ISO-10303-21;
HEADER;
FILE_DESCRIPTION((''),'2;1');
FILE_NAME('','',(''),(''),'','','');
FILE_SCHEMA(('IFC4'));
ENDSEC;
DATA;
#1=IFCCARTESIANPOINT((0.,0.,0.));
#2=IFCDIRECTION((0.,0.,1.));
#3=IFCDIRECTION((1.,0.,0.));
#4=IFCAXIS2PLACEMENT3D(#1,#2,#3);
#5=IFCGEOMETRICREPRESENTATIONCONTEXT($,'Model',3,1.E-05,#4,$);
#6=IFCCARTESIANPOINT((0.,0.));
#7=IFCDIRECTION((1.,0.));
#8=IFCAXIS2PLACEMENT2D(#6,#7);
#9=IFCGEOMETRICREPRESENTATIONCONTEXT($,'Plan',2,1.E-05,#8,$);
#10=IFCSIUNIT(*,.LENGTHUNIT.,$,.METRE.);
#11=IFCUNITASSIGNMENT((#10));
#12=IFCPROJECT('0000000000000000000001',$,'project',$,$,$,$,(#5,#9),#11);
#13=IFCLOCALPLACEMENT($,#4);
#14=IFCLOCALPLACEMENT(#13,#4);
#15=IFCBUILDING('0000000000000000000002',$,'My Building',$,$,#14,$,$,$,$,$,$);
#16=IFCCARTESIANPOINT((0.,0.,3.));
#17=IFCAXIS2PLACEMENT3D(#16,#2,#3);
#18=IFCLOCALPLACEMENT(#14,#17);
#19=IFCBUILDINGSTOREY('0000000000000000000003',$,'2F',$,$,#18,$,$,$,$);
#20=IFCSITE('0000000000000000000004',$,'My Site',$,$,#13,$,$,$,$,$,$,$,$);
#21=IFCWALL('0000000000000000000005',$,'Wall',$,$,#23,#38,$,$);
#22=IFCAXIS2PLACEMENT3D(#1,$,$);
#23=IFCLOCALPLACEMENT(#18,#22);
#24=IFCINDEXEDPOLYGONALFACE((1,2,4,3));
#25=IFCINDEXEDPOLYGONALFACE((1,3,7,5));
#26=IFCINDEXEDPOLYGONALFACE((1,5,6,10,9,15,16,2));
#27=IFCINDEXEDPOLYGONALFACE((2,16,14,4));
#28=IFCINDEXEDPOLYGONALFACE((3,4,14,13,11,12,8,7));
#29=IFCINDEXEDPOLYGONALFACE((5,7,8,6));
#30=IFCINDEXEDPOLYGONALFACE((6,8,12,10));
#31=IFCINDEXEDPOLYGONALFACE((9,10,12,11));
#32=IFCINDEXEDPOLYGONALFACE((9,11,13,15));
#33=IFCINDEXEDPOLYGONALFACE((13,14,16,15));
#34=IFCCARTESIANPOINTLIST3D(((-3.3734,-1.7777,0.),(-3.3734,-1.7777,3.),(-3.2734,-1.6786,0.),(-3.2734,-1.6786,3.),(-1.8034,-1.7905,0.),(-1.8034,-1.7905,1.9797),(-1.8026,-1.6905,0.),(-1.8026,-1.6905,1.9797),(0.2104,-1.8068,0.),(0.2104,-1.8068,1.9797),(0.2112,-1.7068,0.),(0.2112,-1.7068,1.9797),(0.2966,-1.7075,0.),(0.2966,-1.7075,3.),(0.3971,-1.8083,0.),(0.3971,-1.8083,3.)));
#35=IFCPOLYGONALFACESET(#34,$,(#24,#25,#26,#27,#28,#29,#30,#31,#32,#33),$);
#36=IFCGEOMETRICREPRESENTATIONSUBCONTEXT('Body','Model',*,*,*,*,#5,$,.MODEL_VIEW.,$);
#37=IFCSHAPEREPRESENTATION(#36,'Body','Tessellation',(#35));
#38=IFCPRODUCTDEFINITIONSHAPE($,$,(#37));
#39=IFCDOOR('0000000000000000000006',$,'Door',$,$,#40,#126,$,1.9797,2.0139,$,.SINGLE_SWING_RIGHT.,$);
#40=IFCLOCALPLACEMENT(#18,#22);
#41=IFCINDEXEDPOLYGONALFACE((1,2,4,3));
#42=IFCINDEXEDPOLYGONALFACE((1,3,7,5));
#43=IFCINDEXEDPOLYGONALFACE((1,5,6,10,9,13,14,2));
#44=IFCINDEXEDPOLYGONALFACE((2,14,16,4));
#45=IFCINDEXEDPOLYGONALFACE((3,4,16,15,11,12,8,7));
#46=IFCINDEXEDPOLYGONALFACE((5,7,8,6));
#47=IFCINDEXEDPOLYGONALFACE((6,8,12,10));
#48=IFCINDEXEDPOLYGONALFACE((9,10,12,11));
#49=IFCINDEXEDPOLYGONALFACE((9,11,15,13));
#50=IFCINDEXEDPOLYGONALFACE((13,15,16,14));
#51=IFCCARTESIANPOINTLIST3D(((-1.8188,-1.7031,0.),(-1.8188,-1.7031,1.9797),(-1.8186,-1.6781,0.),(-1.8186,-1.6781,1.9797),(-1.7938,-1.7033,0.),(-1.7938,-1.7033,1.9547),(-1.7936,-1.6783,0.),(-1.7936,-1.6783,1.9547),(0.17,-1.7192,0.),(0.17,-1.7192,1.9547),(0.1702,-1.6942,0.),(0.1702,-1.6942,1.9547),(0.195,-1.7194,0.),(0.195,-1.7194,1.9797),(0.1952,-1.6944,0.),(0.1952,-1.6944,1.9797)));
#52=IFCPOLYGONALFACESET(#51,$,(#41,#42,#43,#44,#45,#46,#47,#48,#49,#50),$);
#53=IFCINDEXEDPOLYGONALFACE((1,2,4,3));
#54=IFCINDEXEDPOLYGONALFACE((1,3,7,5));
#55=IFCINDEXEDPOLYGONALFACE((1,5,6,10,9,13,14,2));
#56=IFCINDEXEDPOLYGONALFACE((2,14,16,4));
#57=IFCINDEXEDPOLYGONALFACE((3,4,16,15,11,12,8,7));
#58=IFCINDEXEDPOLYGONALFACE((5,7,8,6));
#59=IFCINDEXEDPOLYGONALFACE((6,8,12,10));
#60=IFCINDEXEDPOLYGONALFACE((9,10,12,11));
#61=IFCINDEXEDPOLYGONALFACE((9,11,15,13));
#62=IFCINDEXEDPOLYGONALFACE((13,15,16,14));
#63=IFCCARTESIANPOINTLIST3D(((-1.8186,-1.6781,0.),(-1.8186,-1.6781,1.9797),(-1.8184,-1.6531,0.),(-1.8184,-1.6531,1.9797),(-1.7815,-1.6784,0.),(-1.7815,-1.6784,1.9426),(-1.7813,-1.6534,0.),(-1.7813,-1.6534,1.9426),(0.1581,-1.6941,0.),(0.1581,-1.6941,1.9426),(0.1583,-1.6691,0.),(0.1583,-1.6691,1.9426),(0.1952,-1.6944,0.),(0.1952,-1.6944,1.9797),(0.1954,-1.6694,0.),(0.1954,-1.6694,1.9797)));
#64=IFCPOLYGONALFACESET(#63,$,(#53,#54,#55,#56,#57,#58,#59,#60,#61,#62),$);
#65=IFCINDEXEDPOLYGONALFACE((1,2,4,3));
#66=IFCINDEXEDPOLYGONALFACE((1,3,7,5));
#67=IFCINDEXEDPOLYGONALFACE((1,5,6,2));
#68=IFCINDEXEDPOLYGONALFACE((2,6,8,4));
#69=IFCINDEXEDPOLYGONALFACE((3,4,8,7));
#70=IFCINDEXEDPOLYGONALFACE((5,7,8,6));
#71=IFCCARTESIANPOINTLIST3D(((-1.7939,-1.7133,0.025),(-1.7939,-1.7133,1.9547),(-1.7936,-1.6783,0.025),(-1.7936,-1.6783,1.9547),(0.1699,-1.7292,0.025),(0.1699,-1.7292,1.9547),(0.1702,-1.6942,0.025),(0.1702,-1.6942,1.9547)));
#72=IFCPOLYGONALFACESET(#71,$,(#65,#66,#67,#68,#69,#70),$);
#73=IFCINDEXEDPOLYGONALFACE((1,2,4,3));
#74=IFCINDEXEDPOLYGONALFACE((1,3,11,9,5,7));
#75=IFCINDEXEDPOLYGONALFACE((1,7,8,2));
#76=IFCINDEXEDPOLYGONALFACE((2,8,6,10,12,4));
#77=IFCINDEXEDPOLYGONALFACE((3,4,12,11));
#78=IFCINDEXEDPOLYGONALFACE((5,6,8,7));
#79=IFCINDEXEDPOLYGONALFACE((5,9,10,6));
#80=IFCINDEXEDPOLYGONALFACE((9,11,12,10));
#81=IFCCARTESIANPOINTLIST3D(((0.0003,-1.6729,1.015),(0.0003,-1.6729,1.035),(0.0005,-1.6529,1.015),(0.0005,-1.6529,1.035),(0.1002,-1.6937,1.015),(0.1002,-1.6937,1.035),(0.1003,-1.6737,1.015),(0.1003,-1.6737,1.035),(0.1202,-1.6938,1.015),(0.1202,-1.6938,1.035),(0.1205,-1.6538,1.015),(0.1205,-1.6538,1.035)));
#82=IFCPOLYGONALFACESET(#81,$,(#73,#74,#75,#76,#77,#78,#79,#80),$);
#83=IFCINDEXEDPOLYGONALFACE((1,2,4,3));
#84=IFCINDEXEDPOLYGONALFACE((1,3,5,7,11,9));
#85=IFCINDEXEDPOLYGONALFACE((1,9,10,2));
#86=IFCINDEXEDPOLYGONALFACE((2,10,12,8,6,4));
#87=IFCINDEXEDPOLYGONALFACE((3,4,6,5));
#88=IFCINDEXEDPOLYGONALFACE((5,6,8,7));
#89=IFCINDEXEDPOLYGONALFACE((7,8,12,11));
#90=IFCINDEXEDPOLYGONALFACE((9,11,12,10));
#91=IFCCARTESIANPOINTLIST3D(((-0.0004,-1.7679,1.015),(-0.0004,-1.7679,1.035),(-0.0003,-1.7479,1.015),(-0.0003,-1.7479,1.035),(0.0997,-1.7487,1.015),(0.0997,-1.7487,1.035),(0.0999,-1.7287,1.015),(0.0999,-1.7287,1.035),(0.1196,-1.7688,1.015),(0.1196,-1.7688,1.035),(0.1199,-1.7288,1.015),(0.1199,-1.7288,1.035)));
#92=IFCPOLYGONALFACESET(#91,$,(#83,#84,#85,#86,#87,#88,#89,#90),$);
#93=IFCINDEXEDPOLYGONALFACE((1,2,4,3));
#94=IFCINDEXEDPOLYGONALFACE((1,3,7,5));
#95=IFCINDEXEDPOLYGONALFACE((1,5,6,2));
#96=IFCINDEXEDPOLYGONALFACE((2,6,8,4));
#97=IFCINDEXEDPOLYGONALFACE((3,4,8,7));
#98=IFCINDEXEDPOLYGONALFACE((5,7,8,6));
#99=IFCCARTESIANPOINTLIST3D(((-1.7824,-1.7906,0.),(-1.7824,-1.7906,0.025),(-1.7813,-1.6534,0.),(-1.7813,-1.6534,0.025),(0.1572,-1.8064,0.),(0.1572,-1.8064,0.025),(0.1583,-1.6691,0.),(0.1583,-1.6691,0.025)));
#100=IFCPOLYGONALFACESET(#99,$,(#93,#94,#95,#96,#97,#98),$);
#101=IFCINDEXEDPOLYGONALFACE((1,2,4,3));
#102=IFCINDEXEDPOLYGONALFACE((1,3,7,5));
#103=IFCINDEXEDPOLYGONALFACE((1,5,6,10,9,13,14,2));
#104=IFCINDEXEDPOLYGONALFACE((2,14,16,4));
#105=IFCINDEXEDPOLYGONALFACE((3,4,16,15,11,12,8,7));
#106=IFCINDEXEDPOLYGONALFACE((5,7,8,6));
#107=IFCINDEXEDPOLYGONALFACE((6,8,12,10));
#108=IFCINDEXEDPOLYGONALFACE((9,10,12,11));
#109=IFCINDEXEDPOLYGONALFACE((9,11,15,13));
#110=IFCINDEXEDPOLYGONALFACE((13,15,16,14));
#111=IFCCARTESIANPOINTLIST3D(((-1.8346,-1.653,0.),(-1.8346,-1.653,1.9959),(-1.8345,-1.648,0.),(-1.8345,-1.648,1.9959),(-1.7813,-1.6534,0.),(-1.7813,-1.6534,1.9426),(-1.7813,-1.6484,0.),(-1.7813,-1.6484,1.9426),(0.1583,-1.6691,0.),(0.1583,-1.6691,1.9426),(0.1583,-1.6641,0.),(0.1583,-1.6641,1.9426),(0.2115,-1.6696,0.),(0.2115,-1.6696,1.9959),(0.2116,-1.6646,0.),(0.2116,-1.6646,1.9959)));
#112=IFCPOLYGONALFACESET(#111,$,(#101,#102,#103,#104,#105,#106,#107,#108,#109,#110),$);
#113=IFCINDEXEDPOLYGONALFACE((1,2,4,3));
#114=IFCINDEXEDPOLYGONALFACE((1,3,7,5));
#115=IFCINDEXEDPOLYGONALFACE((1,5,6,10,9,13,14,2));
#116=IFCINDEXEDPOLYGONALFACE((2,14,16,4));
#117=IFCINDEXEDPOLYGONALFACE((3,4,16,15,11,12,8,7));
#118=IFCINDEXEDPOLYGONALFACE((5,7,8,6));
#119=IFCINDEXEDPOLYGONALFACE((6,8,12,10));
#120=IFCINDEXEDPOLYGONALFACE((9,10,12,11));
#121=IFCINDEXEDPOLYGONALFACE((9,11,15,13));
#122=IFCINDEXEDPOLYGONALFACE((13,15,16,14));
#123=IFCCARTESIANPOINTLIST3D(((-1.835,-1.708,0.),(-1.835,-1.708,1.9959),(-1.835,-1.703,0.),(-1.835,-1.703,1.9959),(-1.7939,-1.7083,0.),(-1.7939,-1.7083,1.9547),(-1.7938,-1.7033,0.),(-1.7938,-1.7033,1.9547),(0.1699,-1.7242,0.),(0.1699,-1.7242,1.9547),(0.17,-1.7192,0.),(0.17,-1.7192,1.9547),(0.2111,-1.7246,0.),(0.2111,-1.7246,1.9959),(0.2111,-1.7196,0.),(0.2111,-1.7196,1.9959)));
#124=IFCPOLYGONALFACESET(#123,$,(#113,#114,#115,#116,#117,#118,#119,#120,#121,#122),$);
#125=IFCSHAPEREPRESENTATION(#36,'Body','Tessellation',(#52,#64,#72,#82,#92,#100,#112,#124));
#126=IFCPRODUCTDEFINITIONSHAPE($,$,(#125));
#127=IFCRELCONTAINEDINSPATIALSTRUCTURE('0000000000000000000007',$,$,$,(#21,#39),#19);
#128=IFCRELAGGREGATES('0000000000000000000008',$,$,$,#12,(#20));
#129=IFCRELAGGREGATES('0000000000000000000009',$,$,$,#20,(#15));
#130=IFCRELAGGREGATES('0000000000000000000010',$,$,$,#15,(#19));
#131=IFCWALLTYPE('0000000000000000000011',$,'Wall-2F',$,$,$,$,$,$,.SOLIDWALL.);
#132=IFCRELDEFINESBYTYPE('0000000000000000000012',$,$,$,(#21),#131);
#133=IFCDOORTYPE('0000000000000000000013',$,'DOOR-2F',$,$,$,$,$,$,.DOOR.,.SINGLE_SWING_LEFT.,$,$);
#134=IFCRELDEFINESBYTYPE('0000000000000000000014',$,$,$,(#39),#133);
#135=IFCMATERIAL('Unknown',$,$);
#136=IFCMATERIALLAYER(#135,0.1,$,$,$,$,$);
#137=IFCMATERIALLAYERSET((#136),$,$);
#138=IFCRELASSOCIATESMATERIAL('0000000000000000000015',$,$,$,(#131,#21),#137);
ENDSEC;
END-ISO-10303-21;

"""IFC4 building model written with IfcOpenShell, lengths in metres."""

from ifc_helpers import new_model, entity, si_unit, frame, origin_with_axes, origin_2d_with_axis, place, context, subcontext, project, spatial, line, indexed_curve, outline, extrude, shape, source, transform, mapped, material, layer, layer_set, layer_usage, type_object, type_shapes, element, fill, save


model = new_model("IFC4")

# Units and contexts
model_context = context("Model", 3, precision=1e-05, world=origin_with_axes())
plan_context = context("Plan", 2, precision=1e-05, world=origin_2d_with_axis())
body_context_1 = subcontext(model_context, "Body", "Model", "MODEL_VIEW")
body_context_2 = subcontext(plan_context, "Body", "Plan", "PLAN_VIEW")
ifc_project = project(units=[si_unit("LENGTHUNIT", "METRE")], contexts=[model_context, plan_context])

# Site, building, storey
site_placement = place(None, origin_with_axes())
site = spatial("IfcSite", under=ifc_project, at=site_placement, Name="My Site")
building_placement = place(site_placement, origin_with_axes())
building = spatial("IfcBuilding", under=site, at=building_placement, Name="My Building")
storey_placement = place(building_placement, frame((0.0, 0.0, 3.0), z_axis=(0.0, 0.0, 1.0), x_axis=(1.0, 0.0, 0.0)))
storey = spatial("IfcBuildingStorey", under=building, at=storey_placement, Name="2F")

# Shared definitions
ifc_material = material(Name="Unknown")

# Shared definitions
ifc_layer_1 = layer(ifc_material, 0.1)
ifc_layer_set_1 = layer_set([ifc_layer_1])
wall_type = type_object("IfcWallType", Name="Wall-2F", PredefinedType="SOLIDWALL", material=ifc_layer_set_1)

# Wall, opening, door
ifc_layer_usage_1 = layer_usage(ifc_layer_set_1, "AXIS2", "POSITIVE", 0.0)
wall_1_placement = place(storey_placement, frame((0.2966, -1.7075, 0.0), z_axis=(0.0, 0.0, 1.0), x_axis=(-0.999967, 0.008106, 0.0)))
wall_1 = element("IfcWall", 1, at=wall_1_placement, inside=storey, type_object=wall_type, material=ifc_layer_usage_1, Name="Wall", context=body_context_1, shape_type="SweptSolid", body=[
    extrude(outline(indexed_curve([(0.0, 0.0), (-0.1013, 0.1), (3.6693, 0.1), (3.5702, 0.0)], segments=[line(1, 2, 3, 4, 1)])), origin_with_axes(), (0.0, 0.0, 1.0), 3.0),
])
shared_shape_1 = source(origin_with_axes(), body_context_1, "Body", "SweptSolid", [
    extrude(outline(indexed_curve([(0.0, 0.0), (2.0139, 0.0), (2.0139, 1.9797), (0.0, 1.9797)], segments=[line(1, 2, 3, 4, 1)])), frame((0.0, -0.6, 0.0), z_axis=(0.0, -1.0, 0.0), x_axis=(1.0, 0.0, 0.0)), (0.0, 0.0, -1.0), 1.2),
])
opening_1_placement = place(wall_1_placement, frame((0.0854, -0.0422, 0.0), z_axis=(0.0, 0.0, 1.0), x_axis=(1.0, 0.0, 0.0)))
opening_1 = element("IfcOpeningElement", 2, at=opening_1_placement, cuts=wall_1, PredefinedType="OPENING", context=body_context_1, shape_type="MappedRepresentation", body=[
    mapped(shared_shape_1, transform((0.0, 0.0, 0.0), x_axis=(1.0, 0.0, 0.0), y_axis=(0.0, 1.0, 0.0), z_axis=(0.0, 0.0, 1.0), scale=1.0)),
])
door_type_1 = type_object("IfcDoorType", Name="DOOR-2F", OperationType="SINGLE_SWING_LEFT", PredefinedType="DOOR")
shared_shape_2 = source(origin_with_axes(), body_context_1, "Body", "SweptSolid", [
    extrude(outline(indexed_curve([(0.0, 0.0), (0.0, 1.9797), (2.0139, 1.9797), (2.0139, 0.0), (1.9889, 0.0), (1.9889, 1.9547), (0.025, 1.9547), (0.025, 0.0)], segments=[line(1, 2, 3, 4, 5, 6, 7, 8, 1)])), frame((0.0, 0.025, 0.0), z_axis=(0.0, -1.0, 0.0), x_axis=(1.0, 0.0, 0.0)), (0.0, 0.0, -1.0), 0.025),
    extrude(outline(indexed_curve([(0.0, 0.0), (0.0, 1.9797), (2.0139, 1.9797), (2.0139, 0.0), (1.9768, 0.0), (1.9768, 1.9426), (0.0371, 1.9426), (0.0371, 0.0)], segments=[line(1, 2, 3, 4, 5, 6, 7, 8, 1)])), frame((0.0, 0.0, 0.0), z_axis=(0.0, -1.0, 0.0), x_axis=(1.0, 0.0, 0.0)), (0.0, 0.0, -1.0), 0.025),
    extrude(outline(indexed_curve([(0.0, 0.0), (1.9639, 0.0), (1.9639, 0.035), (0.0, 0.035)], segments=[line(1, 2, 3, 4, 1)])), frame((0.025, 0.025, 0.025), z_axis=(0.0, 0.0, 1.0), x_axis=(1.0, 0.0, 0.0)), (0.0, 0.0, 1.0), 1.9297),
    extrude(outline(indexed_curve([(0.0, 0.0), (0.0, -0.04), (0.12, -0.04), (0.12, -0.02), (0.02, -0.02), (0.02, 0.0)], segments=[line(1, 2, 3, 4, 5, 6, 1)])), frame((0.075, 0.025, 1.015), z_axis=(0.0, 0.0, 1.0), x_axis=(1.0, 0.0, 0.0)), (0.0, 0.0, 1.0), 0.02),
    extrude(outline(indexed_curve([(0.0, 0.0), (0.0, 0.04), (0.12, 0.04), (0.12, 0.02), (0.02, 0.02), (0.02, 0.0)], segments=[line(1, 2, 3, 4, 5, 6, 1)])), frame((0.075, 0.06, 1.015), z_axis=(0.0, 0.0, 1.0), x_axis=(1.0, 0.0, 0.0)), (0.0, 0.0, 1.0), 0.02),
    extrude(outline(indexed_curve([(0.0, 0.0), (1.9397, 0.0), (1.9397, 0.1372), (0.0, 0.1372)], segments=[line(1, 2, 3, 4, 1)])), frame((0.0371, 0.0, 0.0), z_axis=(0.0, 0.0, 1.0), x_axis=(1.0, 0.0, 0.0)), (0.0, 0.0, 1.0), 0.025),
    extrude(outline(indexed_curve([(0.0, 0.0), (0.0, 1.9959), (2.0462, 1.9959), (2.0462, 0.0), (1.9929, 0.0), (1.9929, 1.9426), (0.0532, 1.9426), (0.0532, 0.0)], segments=[line(1, 2, 3, 4, 5, 6, 7, 8, 1)])), frame((-0.0162, -0.005, 0.0), z_axis=(0.0, -1.0, 0.0), x_axis=(1.0, 0.0, 0.0)), (0.0, 0.0, -1.0), 0.005),
    extrude(outline(indexed_curve([(0.0, 0.0), (0.0, 1.9959), (2.0462, 1.9959), (2.0462, 0.0), (2.005, 0.0), (2.005, 1.9547), (0.0412, 1.9547), (0.0412, 0.0)], segments=[line(1, 2, 3, 4, 5, 6, 7, 8, 1)])), frame((-0.0162, 0.05, 0.0), z_axis=(0.0, -1.0, 0.0), x_axis=(1.0, 0.0, 0.0)), (0.0, 0.0, -1.0), 0.005),
])
shared_shape_3 = source(origin_with_axes(), body_context_2, "Body", "Curve2D", [
    entity("IfcIndexedPolyCurve", entity("IfcCartesianPointList2D", [[0.0, 0.0], [0.0, 0.05], [0.025, 0.05], [0.025, 0.025], [0.0371, 0.025], [0.0371, 0.0]]), [entity("IfcLineIndex", [1, 2, 3, 4, 5, 6, 1])]),
    entity("IfcIndexedPolyCurve", entity("IfcCartesianPointList2D", [[2.0139, 0.0], [2.0139, 0.05], [1.9889, 0.05], [1.9889, 0.025], [1.9768, 0.025], [1.9768, 0.0]]), [entity("IfcLineIndex", [1, 2, 3, 4, 5, 6, 1])]),
    entity("IfcTrimmedCurve", entity("IfcEllipse", entity("IfcAxis2Placement2D", entity("IfcCartesianPoint", [1.9539, 0.05]), entity("IfcDirection", [1.0, 0.0])), 1.9289, 1.9639), [entity("IfcCartesianPoint", [1.9539, 2.0139])], [entity("IfcCartesianPoint", [0.025, 0.05])], True, "CARTESIAN"),
    entity("IfcIndexedPolyCurve", entity("IfcCartesianPointList2D", [[1.9889, 0.05], [1.9539, 0.05], [1.9539, 2.0139], [1.9889, 2.0139]]), [entity("IfcLineIndex", [1, 2, 3, 4, 1])]),
])
type_shapes(door_type_1, [shared_shape_2, shared_shape_3])
door_1_placement = place(opening_1_placement, frame((0.0162, 0.0049, 0.0), z_axis=(0.0, 0.0, 1.0), x_axis=(1.0, 0.0, 0.0)))
door_1 = element("IfcDoor", 3, at=door_1_placement, inside=storey, type_object=door_type_1, Name="Door", OperationType="SINGLE_SWING_RIGHT", OverallHeight=1.9797, OverallWidth=2.0139, shapes=[
    shape(body_context_1, "Body", "MappedRepresentation", [mapped(shared_shape_2, transform((0.0, 0.0, 0.0), x_axis=(1.0, 0.0, 0.0), y_axis=(0.0, 1.0, 0.0), z_axis=(0.0, 0.0, 1.0), scale=1.0))]),
    shape(body_context_2, "Body", "MappedRepresentation", [mapped(shared_shape_3, transform((0.0, 0.0, 0.0), x_axis=(1.0, 0.0, 0.0), y_axis=(0.0, 1.0, 0.0), z_axis=(0.0, 0.0, 1.0), scale=1.0))]),
])
fill(opening_1, door_1)

save(model, "model.ifc")
